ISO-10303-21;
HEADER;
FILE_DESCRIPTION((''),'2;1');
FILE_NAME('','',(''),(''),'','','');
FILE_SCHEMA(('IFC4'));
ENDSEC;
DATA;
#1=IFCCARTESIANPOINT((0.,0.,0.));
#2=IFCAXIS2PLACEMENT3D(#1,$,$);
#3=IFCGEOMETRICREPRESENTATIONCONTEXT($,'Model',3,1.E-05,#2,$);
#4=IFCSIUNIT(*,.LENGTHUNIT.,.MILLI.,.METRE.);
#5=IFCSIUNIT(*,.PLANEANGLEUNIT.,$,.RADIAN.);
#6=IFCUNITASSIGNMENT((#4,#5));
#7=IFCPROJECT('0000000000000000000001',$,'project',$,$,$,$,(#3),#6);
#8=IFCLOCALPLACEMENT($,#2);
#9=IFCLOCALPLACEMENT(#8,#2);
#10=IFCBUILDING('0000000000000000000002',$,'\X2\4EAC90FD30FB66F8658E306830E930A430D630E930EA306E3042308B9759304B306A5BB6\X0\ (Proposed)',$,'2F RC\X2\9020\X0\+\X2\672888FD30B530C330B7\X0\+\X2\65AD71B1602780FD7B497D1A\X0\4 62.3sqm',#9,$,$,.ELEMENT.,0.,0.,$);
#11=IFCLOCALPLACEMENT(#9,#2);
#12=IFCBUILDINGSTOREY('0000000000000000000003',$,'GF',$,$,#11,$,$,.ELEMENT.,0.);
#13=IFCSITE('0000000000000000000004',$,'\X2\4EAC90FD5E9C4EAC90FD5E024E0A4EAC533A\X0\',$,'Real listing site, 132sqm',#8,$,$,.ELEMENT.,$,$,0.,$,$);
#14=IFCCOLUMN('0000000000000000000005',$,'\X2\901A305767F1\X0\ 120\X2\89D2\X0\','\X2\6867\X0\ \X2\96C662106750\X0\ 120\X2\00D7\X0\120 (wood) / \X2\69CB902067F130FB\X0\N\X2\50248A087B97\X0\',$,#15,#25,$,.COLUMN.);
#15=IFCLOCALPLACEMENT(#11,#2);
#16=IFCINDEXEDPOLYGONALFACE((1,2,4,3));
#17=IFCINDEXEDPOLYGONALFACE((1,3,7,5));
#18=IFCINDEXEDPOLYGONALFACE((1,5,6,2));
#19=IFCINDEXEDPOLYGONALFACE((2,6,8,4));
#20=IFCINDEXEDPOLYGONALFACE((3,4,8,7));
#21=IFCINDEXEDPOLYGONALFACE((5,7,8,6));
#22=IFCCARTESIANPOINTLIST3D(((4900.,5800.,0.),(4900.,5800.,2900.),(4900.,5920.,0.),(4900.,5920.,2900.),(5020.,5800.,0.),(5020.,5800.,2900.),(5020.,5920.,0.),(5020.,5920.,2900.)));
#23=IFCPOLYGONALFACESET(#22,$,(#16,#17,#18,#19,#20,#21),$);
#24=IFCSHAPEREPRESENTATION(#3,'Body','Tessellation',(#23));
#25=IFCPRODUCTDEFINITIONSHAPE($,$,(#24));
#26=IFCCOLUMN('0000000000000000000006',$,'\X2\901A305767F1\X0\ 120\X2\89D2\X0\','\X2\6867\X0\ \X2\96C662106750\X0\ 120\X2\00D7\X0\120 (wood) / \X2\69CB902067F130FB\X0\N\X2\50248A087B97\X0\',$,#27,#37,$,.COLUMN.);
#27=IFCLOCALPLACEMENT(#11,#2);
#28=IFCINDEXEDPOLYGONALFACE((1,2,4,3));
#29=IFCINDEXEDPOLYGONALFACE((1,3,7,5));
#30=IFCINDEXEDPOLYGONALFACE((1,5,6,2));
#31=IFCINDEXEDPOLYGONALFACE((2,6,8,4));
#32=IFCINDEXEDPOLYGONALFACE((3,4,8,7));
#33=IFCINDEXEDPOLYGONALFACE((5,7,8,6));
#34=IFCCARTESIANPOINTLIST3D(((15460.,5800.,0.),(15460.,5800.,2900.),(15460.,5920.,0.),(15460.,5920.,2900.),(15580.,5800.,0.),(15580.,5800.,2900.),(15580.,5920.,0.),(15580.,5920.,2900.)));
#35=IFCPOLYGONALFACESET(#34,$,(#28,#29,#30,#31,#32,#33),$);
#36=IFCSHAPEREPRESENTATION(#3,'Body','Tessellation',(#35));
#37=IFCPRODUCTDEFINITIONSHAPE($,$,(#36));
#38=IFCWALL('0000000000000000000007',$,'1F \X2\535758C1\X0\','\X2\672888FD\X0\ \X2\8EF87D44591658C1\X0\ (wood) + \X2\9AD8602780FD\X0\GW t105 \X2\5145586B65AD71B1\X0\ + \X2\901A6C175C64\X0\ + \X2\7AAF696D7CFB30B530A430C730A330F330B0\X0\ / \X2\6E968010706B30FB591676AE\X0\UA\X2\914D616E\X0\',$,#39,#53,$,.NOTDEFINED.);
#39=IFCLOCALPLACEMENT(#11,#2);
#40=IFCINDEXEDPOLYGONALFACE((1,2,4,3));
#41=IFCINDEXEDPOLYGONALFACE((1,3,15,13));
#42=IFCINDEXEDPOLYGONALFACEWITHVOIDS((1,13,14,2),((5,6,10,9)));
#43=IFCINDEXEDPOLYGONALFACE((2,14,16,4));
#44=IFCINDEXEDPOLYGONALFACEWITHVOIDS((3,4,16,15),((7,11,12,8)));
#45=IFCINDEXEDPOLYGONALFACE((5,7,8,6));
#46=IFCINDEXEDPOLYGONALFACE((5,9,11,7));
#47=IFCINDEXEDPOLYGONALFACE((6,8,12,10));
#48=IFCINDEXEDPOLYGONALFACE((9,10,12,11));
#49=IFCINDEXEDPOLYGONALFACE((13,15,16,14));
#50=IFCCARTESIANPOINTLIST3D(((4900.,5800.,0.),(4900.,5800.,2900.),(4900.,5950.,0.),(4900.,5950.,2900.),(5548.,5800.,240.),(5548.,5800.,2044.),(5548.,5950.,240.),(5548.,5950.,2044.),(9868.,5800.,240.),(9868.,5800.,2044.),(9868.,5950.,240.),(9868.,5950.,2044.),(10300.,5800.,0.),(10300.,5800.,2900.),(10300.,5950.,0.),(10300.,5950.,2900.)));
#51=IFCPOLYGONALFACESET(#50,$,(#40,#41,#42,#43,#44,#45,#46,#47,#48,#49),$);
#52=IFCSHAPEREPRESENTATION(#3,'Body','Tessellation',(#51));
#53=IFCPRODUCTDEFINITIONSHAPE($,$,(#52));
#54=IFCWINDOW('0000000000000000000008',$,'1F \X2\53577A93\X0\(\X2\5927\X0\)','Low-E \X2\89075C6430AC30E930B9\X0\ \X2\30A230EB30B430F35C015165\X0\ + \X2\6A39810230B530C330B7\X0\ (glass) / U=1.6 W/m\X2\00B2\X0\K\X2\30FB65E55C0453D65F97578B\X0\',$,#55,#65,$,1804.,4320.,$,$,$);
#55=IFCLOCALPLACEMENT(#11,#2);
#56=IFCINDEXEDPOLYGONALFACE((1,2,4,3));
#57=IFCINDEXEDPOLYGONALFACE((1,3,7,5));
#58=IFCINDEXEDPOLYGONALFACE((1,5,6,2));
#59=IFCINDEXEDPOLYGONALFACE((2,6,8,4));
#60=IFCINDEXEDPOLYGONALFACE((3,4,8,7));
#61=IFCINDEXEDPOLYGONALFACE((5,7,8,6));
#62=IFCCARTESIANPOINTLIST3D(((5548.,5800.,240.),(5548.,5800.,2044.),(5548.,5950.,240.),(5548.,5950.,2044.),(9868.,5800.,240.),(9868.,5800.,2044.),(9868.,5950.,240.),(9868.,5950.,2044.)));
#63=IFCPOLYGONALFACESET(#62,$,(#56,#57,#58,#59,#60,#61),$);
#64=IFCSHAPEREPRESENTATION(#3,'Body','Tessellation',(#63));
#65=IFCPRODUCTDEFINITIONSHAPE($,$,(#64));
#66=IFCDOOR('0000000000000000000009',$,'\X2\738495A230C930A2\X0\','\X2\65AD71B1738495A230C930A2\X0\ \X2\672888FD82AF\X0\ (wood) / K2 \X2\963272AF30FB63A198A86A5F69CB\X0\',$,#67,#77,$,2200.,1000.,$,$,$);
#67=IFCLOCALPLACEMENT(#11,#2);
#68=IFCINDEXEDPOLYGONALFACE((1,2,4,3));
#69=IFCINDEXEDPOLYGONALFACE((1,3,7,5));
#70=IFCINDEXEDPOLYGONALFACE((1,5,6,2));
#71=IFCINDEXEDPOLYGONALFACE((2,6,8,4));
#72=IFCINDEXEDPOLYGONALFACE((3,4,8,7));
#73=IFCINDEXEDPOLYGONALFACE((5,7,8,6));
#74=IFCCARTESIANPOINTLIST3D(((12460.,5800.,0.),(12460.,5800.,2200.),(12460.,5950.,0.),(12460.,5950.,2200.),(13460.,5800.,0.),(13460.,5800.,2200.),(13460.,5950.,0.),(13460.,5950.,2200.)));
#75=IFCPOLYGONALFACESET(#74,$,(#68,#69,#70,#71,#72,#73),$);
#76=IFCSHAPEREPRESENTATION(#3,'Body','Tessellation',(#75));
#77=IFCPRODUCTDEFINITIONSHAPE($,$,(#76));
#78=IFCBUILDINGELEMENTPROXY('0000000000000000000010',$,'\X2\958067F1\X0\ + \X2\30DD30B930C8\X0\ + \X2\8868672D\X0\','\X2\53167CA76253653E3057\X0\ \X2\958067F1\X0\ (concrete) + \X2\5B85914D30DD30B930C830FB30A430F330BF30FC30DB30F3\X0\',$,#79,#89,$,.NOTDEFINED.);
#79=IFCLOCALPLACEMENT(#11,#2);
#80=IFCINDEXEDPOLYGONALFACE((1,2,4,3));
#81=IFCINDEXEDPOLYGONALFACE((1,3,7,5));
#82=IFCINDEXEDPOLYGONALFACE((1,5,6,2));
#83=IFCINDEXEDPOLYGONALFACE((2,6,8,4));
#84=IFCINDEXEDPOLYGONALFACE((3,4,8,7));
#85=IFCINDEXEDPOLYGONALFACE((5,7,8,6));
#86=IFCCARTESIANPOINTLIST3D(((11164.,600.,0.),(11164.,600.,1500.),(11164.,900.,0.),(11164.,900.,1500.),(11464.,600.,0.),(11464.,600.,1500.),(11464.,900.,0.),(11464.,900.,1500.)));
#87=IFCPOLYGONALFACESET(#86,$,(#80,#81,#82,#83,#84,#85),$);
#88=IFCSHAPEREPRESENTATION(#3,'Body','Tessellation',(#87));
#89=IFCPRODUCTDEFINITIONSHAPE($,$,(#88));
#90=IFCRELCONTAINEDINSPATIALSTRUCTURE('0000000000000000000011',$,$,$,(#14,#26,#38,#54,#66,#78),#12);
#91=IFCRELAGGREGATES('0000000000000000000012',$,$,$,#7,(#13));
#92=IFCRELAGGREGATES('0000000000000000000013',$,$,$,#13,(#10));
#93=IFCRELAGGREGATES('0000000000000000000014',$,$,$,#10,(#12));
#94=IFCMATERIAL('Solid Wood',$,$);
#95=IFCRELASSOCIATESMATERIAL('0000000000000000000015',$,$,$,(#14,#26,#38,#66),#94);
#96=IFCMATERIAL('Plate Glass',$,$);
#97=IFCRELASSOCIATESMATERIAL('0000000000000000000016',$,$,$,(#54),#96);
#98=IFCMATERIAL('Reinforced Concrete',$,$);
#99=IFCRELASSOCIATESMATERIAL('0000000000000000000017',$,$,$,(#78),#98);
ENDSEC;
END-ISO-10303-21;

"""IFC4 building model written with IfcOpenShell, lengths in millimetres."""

from ifc_helpers import new_model, si_unit, frame, frame_2d, origin, place, context, project, spatial, rectangle, extrude, material, element, fill, save


model = new_model("IFC4")

# Units and contexts
model_context = context("Model", 3, precision=1e-05, world=origin())
ifc_project = project(units=[si_unit("LENGTHUNIT", "METRE", prefix="MILLI"), si_unit("PLANEANGLEUNIT", "RADIAN")], contexts=[model_context])

# Site, building, storey
site_placement = place(None, origin())
site = spatial("IfcSite", under=ifc_project, at=site_placement, Name="京都府京都市上京区", ObjectType="Real listing site, 132sqm", CompositionType="ELEMENT", RefElevation=0.0)
building_placement = place(site_placement, origin())
building = spatial("IfcBuilding", under=site, at=building_placement, Name="京都・書斎とライブラリのある静かな家 (Proposed)", ObjectType="2F RC造+木製サッシ+断熱性能等級4 62.3sqm", CompositionType="ELEMENT", ElevationOfRefHeight=0.0, ElevationOfTerrain=0.0)
storey_placement = place(building_placement, origin())
storey = spatial("IfcBuildingStorey", under=building, at=storey_placement, Name="GF", CompositionType="ELEMENT", Elevation=0.0)

# Columns
ifc_material_1 = material(Name="Solid Wood")
column_1_placement = place(storey_placement, frame((2450.0, 2900.0, 0.0)))
element("IfcColumn", 1, at=column_1_placement, inside=storey, material=ifc_material_1, Name="通し柱 120角", Description="桧 集成材 120×120 (wood) / 構造柱・N値計算", PredefinedType="COLUMN", context=model_context, shape_type="SweptSolid", body=[
    extrude(rectangle(XDim=120.0, YDim=120.0, at=frame_2d((60.0, 60.0))), frame((2450.0, 2900.0, 0.0)), (0.0, 0.0, 1.0), 2900.0),
])
column_2_placement = place(storey_placement, frame((7730.0, 2900.0, 0.0)))
element("IfcColumn", 2, at=column_2_placement, inside=storey, material=ifc_material_1, Name="通し柱 120角", Description="桧 集成材 120×120 (wood) / 構造柱・N値計算", PredefinedType="COLUMN", context=model_context, shape_type="SweptSolid", body=[
    extrude(rectangle(XDim=120.0, YDim=120.0, at=frame_2d((60.0, 60.0))), frame((7730.0, 2900.0, 0.0)), (0.0, 0.0, 1.0), 2900.0),
])

# Shared definitions
ifc_material_2 = material(Name="Reinforced Concrete")

# Wall, openings, window, door
wall_1_placement = place(storey_placement, frame((2450.0, 2900.0, 0.0)))
wall_1 = element("IfcWall", 3, at=wall_1_placement, inside=storey, material=ifc_material_1, Name="1F 南壁", Description="木製 軸組外壁 (wood) + 高性能GW t105 充填断熱 + 通気層 + 窯業系サイディング / 準耐火・外皮UA配慮", PredefinedType="NOTDEFINED", context=model_context, shape_type="SweptSolid", body=[
    extrude(rectangle(XDim=5400.0, YDim=150.0, at=frame_2d((2700.0, 75.0))), frame((2450.0, 2900.0, 0.0)), (0.0, 0.0, 1.0), 2900.0),
])
opening_1_placement = place(storey_placement, frame((2774.0, 2900.0, 120.0)))
opening_1 = element("IfcOpeningElement", 4, at=opening_1_placement, cuts=wall_1, PredefinedType="NOTDEFINED", context=model_context, shape_type="SweptSolid", body=[
    extrude(rectangle(XDim=4320.0, YDim=150.0, at=frame_2d((2160.0, 75.0))), frame((2774.0, 2900.0, 120.0)), (0.0, 0.0, 1.0), 1804.0),
])
opening_2_placement = place(storey_placement, frame((6230.0, 2900.0, 0.0)))
opening_2 = element("IfcOpeningElement", 5, at=opening_2_placement, cuts=wall_1, PredefinedType="NOTDEFINED", context=model_context, shape_type="SweptSolid", body=[
    extrude(rectangle(XDim=1000.0, YDim=150.0, at=frame_2d((500.0, 75.0))), frame((6230.0, 2900.0, 0.0)), (0.0, 0.0, 1.0), 2200.0),
])
ifc_material_3 = material(Name="Plate Glass")
window_1_placement = place(storey_placement, frame((2774.0, 2900.0, 120.0)))
window_1 = element("IfcWindow", 6, at=window_1_placement, inside=storey, material=ifc_material_3, Name="1F 南窓(大)", Description="Low-E 複層ガラス アルゴン封入 + 樹脂サッシ (glass) / U=1.6 W/m²K・日射取得型", OverallHeight=1804.0, OverallWidth=4320.0, context=model_context, shape_type="SweptSolid", body=[
    extrude(rectangle(XDim=4320.0, YDim=150.0, at=frame_2d((2160.0, 75.0))), frame((2774.0, 2900.0, 120.0)), (0.0, 0.0, 1.0), 1804.0),
])
fill(opening_1, window_1)
door_1_placement = place(storey_placement, frame((6230.0, 2900.0, 0.0)))
door_1 = element("IfcDoor", 7, at=door_1_placement, inside=storey, material=ifc_material_1, Name="玄関ドア", Description="断熱玄関ドア 木製芯 (wood) / K2 防犯・採風機構", OverallHeight=2200.0, OverallWidth=1000.0, context=model_context, shape_type="SweptSolid", body=[
    extrude(rectangle(XDim=1000.0, YDim=150.0, at=frame_2d((500.0, 75.0))), frame((6230.0, 2900.0, 0.0)), (0.0, 0.0, 1.0), 2200.0),
])
fill(opening_2, door_1)

# Building element proxy
proxy_placement = place(storey_placement, frame((5582.0, 300.0, 0.0)))
element("IfcBuildingElementProxy", 8, at=proxy_placement, inside=storey, material=ifc_material_2, Name="門柱 + ポスト + 表札", Description="化粧打放し 門柱 (concrete) + 宅配ポスト・インターホン", PredefinedType="NOTDEFINED", context=model_context, shape_type="SweptSolid", body=[
    extrude(rectangle(XDim=300.0, YDim=300.0, at=frame_2d((150.0, 150.0))), frame((5582.0, 300.0, 0.0)), (0.0, 0.0, 1.0), 1500.0),
])

save(model, "model.ifc")
